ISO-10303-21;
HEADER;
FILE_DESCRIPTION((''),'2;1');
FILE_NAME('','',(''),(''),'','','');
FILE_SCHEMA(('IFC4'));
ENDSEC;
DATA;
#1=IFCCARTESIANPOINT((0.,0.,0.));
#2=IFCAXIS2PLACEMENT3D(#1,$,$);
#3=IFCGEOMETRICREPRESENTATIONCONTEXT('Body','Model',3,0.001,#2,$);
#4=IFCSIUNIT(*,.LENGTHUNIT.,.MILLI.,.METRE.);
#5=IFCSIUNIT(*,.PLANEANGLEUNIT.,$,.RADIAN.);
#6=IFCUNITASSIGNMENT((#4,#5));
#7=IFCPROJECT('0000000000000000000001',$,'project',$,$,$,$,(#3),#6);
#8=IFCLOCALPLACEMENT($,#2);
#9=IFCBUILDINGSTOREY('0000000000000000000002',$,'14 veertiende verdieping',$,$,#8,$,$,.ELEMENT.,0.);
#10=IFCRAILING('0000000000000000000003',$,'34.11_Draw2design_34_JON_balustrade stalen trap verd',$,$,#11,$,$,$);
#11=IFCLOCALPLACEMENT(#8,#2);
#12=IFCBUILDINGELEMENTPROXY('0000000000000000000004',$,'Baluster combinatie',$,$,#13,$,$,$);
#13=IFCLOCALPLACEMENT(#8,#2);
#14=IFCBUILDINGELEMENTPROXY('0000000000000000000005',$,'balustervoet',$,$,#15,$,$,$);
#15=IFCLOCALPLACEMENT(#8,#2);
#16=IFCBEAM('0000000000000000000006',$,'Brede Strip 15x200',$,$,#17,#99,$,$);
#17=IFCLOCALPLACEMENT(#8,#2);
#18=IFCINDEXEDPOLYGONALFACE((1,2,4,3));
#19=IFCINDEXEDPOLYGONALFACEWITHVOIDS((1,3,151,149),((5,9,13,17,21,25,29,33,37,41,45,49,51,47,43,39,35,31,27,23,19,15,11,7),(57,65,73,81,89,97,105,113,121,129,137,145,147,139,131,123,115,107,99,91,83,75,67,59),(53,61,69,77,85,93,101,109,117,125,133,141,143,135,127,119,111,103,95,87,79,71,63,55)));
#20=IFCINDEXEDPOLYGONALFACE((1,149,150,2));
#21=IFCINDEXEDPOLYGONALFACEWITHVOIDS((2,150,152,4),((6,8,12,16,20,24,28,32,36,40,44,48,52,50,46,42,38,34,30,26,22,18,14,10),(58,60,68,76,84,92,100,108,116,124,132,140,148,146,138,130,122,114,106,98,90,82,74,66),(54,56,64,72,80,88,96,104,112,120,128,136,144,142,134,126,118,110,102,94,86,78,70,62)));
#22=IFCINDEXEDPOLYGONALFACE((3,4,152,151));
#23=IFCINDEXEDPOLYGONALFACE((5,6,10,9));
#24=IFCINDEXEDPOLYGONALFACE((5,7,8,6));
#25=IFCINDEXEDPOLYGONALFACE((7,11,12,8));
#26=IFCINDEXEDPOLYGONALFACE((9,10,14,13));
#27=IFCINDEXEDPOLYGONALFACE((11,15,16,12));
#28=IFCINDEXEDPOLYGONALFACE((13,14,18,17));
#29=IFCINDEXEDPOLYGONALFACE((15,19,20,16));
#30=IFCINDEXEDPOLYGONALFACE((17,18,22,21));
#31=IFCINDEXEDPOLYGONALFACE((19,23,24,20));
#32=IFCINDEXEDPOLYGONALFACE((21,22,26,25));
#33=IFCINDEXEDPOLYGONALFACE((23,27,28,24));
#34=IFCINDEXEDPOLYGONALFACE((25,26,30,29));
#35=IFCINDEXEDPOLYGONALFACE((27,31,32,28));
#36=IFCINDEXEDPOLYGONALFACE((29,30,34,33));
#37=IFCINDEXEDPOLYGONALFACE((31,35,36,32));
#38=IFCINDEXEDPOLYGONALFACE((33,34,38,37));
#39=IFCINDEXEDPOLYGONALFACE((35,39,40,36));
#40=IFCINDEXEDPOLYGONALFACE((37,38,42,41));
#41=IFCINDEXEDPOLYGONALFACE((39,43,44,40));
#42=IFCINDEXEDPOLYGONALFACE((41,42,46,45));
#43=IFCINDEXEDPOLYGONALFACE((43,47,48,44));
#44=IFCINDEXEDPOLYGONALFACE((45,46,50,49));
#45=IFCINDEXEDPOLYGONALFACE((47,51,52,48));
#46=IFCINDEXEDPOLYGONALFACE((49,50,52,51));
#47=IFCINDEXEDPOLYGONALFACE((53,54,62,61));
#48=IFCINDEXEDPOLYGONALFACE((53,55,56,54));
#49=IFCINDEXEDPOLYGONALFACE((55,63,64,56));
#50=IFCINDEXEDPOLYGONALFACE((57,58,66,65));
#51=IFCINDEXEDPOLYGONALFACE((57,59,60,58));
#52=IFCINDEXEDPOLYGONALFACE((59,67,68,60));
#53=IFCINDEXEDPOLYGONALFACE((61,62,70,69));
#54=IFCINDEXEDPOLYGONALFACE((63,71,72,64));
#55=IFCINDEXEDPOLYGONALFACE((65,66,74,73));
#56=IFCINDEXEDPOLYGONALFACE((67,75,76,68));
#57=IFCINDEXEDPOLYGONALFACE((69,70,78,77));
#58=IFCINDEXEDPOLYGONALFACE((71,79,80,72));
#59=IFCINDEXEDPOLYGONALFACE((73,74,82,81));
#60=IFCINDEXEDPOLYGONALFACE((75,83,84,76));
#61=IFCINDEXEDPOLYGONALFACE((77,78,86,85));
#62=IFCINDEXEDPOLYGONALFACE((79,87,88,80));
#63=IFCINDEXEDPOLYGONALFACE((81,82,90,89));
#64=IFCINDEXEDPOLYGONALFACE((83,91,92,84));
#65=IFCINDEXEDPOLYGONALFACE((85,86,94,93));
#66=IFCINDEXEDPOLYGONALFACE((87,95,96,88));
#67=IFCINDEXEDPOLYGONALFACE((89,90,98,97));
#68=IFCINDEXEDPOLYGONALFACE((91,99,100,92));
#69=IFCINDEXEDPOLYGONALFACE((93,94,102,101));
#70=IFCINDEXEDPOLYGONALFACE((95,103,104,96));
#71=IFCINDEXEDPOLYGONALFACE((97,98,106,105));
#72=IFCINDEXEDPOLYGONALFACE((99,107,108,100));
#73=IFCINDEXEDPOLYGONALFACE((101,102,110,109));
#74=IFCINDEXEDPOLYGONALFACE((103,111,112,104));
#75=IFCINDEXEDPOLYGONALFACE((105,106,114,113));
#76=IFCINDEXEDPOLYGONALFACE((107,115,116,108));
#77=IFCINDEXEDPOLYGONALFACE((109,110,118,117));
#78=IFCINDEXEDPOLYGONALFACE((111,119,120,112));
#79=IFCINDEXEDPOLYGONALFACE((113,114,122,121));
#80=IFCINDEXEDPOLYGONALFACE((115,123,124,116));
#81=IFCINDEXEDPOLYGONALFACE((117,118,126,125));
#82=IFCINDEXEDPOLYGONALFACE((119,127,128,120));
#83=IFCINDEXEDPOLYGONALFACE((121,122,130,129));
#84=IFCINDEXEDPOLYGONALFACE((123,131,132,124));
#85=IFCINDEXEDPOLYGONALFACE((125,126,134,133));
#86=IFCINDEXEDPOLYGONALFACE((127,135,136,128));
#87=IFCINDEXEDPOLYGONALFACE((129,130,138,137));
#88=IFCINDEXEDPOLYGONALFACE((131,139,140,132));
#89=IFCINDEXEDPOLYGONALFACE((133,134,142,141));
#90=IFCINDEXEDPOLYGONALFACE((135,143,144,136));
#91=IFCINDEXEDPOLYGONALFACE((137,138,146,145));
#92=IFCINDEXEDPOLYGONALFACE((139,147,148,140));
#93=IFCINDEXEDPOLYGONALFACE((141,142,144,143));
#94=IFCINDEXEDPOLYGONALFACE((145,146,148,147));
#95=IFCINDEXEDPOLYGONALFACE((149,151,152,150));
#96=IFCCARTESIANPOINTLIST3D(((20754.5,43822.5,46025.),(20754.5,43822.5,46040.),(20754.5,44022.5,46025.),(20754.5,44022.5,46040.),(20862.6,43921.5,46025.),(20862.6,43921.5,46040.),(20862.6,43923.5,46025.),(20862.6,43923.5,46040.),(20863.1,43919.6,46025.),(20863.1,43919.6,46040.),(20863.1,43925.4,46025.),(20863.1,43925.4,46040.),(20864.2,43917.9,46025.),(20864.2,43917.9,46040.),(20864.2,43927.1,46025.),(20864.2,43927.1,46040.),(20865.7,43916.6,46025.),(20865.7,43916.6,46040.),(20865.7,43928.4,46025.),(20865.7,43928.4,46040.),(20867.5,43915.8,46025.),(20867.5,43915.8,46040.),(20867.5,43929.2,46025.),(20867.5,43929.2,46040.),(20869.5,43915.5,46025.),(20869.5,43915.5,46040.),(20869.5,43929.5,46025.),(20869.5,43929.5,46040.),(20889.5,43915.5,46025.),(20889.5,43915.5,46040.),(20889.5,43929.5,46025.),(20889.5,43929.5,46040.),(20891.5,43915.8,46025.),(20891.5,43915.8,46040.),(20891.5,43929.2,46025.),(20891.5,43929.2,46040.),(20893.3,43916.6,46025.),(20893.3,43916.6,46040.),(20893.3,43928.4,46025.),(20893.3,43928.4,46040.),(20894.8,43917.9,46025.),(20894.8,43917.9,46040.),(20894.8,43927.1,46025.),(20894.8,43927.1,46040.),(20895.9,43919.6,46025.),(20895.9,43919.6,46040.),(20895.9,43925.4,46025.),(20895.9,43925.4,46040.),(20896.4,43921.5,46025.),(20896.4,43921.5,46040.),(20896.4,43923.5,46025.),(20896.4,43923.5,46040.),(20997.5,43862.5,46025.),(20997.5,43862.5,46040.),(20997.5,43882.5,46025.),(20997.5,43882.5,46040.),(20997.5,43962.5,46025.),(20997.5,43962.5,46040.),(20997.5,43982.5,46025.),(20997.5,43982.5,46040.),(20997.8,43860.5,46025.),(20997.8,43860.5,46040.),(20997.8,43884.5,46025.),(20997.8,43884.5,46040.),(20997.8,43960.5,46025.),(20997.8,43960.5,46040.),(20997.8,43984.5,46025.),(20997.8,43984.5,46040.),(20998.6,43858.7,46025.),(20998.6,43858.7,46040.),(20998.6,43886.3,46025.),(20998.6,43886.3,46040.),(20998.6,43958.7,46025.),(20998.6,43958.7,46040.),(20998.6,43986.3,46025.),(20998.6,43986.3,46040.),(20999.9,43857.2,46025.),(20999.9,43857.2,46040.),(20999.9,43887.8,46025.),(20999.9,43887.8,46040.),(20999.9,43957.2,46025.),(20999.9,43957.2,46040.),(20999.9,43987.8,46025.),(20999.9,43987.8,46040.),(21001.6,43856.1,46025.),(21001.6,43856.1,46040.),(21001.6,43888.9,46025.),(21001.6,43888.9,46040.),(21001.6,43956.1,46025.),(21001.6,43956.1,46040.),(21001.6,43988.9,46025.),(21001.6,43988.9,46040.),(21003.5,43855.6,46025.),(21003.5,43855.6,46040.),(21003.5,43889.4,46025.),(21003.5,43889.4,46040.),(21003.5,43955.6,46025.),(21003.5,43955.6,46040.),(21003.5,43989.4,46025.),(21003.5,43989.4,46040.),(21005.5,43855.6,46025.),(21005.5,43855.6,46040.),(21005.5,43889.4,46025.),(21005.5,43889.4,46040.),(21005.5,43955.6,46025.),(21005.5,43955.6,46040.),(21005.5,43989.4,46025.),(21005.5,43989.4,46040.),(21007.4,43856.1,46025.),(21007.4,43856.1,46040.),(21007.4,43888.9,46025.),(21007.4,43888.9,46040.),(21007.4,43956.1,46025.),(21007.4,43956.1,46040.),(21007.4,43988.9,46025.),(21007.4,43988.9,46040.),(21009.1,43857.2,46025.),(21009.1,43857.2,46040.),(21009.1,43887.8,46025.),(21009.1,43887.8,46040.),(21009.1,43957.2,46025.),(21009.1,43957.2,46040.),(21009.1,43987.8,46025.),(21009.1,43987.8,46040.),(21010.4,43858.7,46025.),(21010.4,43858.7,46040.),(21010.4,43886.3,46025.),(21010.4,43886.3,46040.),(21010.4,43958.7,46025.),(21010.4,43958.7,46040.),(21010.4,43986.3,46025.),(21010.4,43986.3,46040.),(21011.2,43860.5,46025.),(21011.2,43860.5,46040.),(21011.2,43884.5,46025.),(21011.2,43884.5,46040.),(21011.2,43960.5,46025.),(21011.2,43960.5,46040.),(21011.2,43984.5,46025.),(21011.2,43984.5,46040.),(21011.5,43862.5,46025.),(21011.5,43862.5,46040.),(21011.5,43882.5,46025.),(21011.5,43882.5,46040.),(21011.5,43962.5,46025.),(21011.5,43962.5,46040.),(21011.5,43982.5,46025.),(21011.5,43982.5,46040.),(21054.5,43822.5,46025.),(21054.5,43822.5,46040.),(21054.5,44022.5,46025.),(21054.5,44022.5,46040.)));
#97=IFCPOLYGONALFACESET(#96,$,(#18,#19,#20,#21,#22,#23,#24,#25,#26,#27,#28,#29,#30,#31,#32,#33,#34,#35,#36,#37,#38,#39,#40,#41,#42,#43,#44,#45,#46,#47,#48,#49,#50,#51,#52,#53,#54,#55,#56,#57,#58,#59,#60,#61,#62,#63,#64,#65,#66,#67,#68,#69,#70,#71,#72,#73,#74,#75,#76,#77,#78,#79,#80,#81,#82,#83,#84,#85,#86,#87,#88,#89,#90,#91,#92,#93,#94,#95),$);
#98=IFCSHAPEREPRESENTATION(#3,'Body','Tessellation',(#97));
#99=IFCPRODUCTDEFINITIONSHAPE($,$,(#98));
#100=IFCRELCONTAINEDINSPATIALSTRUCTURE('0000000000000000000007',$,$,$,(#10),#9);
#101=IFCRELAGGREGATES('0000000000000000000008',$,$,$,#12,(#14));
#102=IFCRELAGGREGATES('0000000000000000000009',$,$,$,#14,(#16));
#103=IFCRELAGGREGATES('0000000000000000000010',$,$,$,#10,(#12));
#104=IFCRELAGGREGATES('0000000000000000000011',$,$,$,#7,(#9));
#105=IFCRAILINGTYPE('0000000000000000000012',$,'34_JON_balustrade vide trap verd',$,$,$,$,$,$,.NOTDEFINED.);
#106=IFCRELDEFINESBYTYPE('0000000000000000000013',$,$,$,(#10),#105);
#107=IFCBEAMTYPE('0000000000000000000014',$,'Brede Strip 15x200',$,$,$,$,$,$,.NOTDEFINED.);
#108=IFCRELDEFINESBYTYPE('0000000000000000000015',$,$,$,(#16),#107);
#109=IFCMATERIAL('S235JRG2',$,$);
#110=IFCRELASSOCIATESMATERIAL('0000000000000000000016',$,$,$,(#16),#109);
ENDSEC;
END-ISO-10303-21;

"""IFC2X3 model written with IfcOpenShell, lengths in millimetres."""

from ifc_helpers import new_model, si_unit, point, frame, frame_2d, origin, origin_2d, place, context, project, spatial, circle_curve, line_curve, trimmed, segment, composite_curve, rectangle, outline, extrude, source, transform, mapped, material, type_object, element, aggregate, save


model = new_model("IFC2X3")

# Units and contexts
model_context = context("Model", 3, precision=0.001, world=origin(), identifier="Body")
ifc_project = project(units=[si_unit("LENGTHUNIT", "METRE", prefix="MILLI"), si_unit("PLANEANGLEUNIT", "RADIAN")], contexts=[model_context])

# Storey
storey_placement = place(None, origin())
storey = spatial("IfcBuildingStorey", under=ifc_project, at=storey_placement, Name="14 veertiende verdieping", CompositionType="ELEMENT", Elevation=0.0)

# Shared definitions
ifc_material_1 = material(Name="S235JRG2")

# Railing, building element proxies, beam, openings
railing_type = type_object("IfcRailingType", Name="34_JON_balustrade vide trap verd")
railing_placement = place(storey_placement, frame((-1939.6, -577.1, 100383.6)))
railing = element("IfcRailing", 1, at=railing_placement, inside=storey, type_object=railing_type, Name="34.11_Draw2design_34_JON_balustrade stalen trap verd")
proxy_1_placement = place(railing_placement, frame((22994.2, 44834.6, -54348.6), z_axis=(0.0, 0.0, 1.0), x_axis=(0.0, 1.0, 0.0)))
proxy_1 = element("IfcBuildingElementProxy", 2, at=proxy_1_placement, Name="Baluster combinatie")
proxy_2_placement = place(proxy_1_placement, frame((-45247.5, 21054.5, -49235.0), z_axis=(0.0, 0.0, 1.0), x_axis=(0.0, -1.0, 0.0)))
proxy_2 = element("IfcBuildingElementProxy", 3, at=proxy_2_placement, Name="balustervoet")
aggregate(proxy_1, [proxy_2])
beam_type_1 = type_object("IfcBeamType", Name="Brede Strip 15x200")
shared_shape_1 = source(origin(), model_context, "Body", "SweptSolid", [
    extrude(rectangle(XDim=15.0, YDim=200.0, at=origin_2d()), origin(), (0.0, 0.0, -1.0), 300.0),
])
beam_1_placement = place(proxy_2_placement, frame((21054.5, 44912.5, 49232.5), z_axis=(1.0, 0.0, 0.0), x_axis=(0.0, 0.0, 1.0)))
beam_1 = element("IfcBeam", 4, at=beam_1_placement, type_object=beam_type_1, material=ifc_material_1, Name="Brede Strip 15x200", context=model_context, shape_type="MappedRepresentation", body=[
    mapped(shared_shape_1, transform((0.0, 0.0, 0.0), scale=1.0)),
])
opening_1_placement = place(beam_1_placement, frame((7.5, 0.0, -175.0), z_axis=(-1.0, 0.0, 0.0), x_axis=(0.0, 0.0, -1.0)))
element("IfcOpeningElement", 5, at=opening_1_placement, cuts=beam_1, ObjectType="Opening", context=model_context, shape_type="SweptSolid", body=[
    extrude(outline(composite_curve([segment(trimmed(circle_curve(frame_2d((10.0, 0.0), x_axis=(0.0, -1.0)), 7.0), [point((10.0, 7.0))], [point((10.0, -7.0))], False, "CARTESIAN"), True, "CONTINUOUS"), segment(trimmed(line_curve((10.0, -7.0), (-20.0, 0.0), 20.0), [point((10.0, -7.0))], [point((-10.0, -7.0))], True, "CARTESIAN"), True, "CONTINUOUS"), segment(trimmed(circle_curve(frame_2d((-10.0, 0.0), x_axis=(0.0, -1.0)), 7.0), [point((-10.0, -7.0))], [point((-10.0, 7.0))], False, "CARTESIAN"), True, "CONTINUOUS"), segment(trimmed(line_curve((-10.0, 7.0), (20.0, 0.0), 20.0), [point((-10.0, 7.0))], [point((10.0, 7.0))], True, "CARTESIAN"), True, "CONTINUOUS")], self_intersect=False)), origin(), (0.0, 0.0, 1.0), 15.0),
])
opening_2_placement = place(beam_1_placement, frame((7.5, -50.0, -50.0), z_axis=(-1.0, 0.0, 0.0), x_axis=(0.0, -1.0, 0.0)))
element("IfcOpeningElement", 6, at=opening_2_placement, cuts=beam_1, ObjectType="Opening", context=model_context, shape_type="SweptSolid", body=[
    extrude(outline(composite_curve([segment(trimmed(circle_curve(frame_2d((10.0, 0.0), x_axis=(0.0, -1.0)), 7.0), [point((10.0, 7.0))], [point((10.0, -7.0))], False, "CARTESIAN"), True, "CONTINUOUS"), segment(trimmed(line_curve((10.0, -7.0), (-20.0, 0.0), 20.0), [point((10.0, -7.0))], [point((-10.0, -7.0))], True, "CARTESIAN"), True, "CONTINUOUS"), segment(trimmed(circle_curve(frame_2d((-10.0, 0.0), x_axis=(0.0, -1.0)), 7.0), [point((-10.0, -7.0))], [point((-10.0, 7.0))], False, "CARTESIAN"), True, "CONTINUOUS"), segment(trimmed(line_curve((-10.0, 7.0), (20.0, 0.0), 20.0), [point((-10.0, 7.0))], [point((10.0, 7.0))], True, "CARTESIAN"), True, "CONTINUOUS")], self_intersect=False)), origin(), (0.0, 0.0, 1.0), 15.0),
])
opening_3_placement = place(beam_1_placement, frame((7.5, 50.0, -50.0), z_axis=(-1.0, 0.0, 0.0), x_axis=(0.0, -1.0, 0.0)))
element("IfcOpeningElement", 7, at=opening_3_placement, cuts=beam_1, ObjectType="Opening", context=model_context, shape_type="SweptSolid", body=[
    extrude(outline(composite_curve([segment(trimmed(circle_curve(frame_2d((10.0, 0.0), x_axis=(0.0, -1.0)), 7.0), [point((10.0, 7.0))], [point((10.0, -7.0))], False, "CARTESIAN"), True, "CONTINUOUS"), segment(trimmed(line_curve((10.0, -7.0), (-20.0, 0.0), 20.0), [point((10.0, -7.0))], [point((-10.0, -7.0))], True, "CARTESIAN"), True, "CONTINUOUS"), segment(trimmed(circle_curve(frame_2d((-10.0, 0.0), x_axis=(0.0, -1.0)), 7.0), [point((-10.0, -7.0))], [point((-10.0, 7.0))], False, "CARTESIAN"), True, "CONTINUOUS"), segment(trimmed(line_curve((-10.0, 7.0), (20.0, 0.0), 20.0), [point((-10.0, 7.0))], [point((10.0, 7.0))], True, "CARTESIAN"), True, "CONTINUOUS")], self_intersect=False)), origin(), (0.0, 0.0, 1.0), 15.0),
])
aggregate(proxy_2, [beam_1])
aggregate(railing, [proxy_1])

save(model, "model.ifc")
